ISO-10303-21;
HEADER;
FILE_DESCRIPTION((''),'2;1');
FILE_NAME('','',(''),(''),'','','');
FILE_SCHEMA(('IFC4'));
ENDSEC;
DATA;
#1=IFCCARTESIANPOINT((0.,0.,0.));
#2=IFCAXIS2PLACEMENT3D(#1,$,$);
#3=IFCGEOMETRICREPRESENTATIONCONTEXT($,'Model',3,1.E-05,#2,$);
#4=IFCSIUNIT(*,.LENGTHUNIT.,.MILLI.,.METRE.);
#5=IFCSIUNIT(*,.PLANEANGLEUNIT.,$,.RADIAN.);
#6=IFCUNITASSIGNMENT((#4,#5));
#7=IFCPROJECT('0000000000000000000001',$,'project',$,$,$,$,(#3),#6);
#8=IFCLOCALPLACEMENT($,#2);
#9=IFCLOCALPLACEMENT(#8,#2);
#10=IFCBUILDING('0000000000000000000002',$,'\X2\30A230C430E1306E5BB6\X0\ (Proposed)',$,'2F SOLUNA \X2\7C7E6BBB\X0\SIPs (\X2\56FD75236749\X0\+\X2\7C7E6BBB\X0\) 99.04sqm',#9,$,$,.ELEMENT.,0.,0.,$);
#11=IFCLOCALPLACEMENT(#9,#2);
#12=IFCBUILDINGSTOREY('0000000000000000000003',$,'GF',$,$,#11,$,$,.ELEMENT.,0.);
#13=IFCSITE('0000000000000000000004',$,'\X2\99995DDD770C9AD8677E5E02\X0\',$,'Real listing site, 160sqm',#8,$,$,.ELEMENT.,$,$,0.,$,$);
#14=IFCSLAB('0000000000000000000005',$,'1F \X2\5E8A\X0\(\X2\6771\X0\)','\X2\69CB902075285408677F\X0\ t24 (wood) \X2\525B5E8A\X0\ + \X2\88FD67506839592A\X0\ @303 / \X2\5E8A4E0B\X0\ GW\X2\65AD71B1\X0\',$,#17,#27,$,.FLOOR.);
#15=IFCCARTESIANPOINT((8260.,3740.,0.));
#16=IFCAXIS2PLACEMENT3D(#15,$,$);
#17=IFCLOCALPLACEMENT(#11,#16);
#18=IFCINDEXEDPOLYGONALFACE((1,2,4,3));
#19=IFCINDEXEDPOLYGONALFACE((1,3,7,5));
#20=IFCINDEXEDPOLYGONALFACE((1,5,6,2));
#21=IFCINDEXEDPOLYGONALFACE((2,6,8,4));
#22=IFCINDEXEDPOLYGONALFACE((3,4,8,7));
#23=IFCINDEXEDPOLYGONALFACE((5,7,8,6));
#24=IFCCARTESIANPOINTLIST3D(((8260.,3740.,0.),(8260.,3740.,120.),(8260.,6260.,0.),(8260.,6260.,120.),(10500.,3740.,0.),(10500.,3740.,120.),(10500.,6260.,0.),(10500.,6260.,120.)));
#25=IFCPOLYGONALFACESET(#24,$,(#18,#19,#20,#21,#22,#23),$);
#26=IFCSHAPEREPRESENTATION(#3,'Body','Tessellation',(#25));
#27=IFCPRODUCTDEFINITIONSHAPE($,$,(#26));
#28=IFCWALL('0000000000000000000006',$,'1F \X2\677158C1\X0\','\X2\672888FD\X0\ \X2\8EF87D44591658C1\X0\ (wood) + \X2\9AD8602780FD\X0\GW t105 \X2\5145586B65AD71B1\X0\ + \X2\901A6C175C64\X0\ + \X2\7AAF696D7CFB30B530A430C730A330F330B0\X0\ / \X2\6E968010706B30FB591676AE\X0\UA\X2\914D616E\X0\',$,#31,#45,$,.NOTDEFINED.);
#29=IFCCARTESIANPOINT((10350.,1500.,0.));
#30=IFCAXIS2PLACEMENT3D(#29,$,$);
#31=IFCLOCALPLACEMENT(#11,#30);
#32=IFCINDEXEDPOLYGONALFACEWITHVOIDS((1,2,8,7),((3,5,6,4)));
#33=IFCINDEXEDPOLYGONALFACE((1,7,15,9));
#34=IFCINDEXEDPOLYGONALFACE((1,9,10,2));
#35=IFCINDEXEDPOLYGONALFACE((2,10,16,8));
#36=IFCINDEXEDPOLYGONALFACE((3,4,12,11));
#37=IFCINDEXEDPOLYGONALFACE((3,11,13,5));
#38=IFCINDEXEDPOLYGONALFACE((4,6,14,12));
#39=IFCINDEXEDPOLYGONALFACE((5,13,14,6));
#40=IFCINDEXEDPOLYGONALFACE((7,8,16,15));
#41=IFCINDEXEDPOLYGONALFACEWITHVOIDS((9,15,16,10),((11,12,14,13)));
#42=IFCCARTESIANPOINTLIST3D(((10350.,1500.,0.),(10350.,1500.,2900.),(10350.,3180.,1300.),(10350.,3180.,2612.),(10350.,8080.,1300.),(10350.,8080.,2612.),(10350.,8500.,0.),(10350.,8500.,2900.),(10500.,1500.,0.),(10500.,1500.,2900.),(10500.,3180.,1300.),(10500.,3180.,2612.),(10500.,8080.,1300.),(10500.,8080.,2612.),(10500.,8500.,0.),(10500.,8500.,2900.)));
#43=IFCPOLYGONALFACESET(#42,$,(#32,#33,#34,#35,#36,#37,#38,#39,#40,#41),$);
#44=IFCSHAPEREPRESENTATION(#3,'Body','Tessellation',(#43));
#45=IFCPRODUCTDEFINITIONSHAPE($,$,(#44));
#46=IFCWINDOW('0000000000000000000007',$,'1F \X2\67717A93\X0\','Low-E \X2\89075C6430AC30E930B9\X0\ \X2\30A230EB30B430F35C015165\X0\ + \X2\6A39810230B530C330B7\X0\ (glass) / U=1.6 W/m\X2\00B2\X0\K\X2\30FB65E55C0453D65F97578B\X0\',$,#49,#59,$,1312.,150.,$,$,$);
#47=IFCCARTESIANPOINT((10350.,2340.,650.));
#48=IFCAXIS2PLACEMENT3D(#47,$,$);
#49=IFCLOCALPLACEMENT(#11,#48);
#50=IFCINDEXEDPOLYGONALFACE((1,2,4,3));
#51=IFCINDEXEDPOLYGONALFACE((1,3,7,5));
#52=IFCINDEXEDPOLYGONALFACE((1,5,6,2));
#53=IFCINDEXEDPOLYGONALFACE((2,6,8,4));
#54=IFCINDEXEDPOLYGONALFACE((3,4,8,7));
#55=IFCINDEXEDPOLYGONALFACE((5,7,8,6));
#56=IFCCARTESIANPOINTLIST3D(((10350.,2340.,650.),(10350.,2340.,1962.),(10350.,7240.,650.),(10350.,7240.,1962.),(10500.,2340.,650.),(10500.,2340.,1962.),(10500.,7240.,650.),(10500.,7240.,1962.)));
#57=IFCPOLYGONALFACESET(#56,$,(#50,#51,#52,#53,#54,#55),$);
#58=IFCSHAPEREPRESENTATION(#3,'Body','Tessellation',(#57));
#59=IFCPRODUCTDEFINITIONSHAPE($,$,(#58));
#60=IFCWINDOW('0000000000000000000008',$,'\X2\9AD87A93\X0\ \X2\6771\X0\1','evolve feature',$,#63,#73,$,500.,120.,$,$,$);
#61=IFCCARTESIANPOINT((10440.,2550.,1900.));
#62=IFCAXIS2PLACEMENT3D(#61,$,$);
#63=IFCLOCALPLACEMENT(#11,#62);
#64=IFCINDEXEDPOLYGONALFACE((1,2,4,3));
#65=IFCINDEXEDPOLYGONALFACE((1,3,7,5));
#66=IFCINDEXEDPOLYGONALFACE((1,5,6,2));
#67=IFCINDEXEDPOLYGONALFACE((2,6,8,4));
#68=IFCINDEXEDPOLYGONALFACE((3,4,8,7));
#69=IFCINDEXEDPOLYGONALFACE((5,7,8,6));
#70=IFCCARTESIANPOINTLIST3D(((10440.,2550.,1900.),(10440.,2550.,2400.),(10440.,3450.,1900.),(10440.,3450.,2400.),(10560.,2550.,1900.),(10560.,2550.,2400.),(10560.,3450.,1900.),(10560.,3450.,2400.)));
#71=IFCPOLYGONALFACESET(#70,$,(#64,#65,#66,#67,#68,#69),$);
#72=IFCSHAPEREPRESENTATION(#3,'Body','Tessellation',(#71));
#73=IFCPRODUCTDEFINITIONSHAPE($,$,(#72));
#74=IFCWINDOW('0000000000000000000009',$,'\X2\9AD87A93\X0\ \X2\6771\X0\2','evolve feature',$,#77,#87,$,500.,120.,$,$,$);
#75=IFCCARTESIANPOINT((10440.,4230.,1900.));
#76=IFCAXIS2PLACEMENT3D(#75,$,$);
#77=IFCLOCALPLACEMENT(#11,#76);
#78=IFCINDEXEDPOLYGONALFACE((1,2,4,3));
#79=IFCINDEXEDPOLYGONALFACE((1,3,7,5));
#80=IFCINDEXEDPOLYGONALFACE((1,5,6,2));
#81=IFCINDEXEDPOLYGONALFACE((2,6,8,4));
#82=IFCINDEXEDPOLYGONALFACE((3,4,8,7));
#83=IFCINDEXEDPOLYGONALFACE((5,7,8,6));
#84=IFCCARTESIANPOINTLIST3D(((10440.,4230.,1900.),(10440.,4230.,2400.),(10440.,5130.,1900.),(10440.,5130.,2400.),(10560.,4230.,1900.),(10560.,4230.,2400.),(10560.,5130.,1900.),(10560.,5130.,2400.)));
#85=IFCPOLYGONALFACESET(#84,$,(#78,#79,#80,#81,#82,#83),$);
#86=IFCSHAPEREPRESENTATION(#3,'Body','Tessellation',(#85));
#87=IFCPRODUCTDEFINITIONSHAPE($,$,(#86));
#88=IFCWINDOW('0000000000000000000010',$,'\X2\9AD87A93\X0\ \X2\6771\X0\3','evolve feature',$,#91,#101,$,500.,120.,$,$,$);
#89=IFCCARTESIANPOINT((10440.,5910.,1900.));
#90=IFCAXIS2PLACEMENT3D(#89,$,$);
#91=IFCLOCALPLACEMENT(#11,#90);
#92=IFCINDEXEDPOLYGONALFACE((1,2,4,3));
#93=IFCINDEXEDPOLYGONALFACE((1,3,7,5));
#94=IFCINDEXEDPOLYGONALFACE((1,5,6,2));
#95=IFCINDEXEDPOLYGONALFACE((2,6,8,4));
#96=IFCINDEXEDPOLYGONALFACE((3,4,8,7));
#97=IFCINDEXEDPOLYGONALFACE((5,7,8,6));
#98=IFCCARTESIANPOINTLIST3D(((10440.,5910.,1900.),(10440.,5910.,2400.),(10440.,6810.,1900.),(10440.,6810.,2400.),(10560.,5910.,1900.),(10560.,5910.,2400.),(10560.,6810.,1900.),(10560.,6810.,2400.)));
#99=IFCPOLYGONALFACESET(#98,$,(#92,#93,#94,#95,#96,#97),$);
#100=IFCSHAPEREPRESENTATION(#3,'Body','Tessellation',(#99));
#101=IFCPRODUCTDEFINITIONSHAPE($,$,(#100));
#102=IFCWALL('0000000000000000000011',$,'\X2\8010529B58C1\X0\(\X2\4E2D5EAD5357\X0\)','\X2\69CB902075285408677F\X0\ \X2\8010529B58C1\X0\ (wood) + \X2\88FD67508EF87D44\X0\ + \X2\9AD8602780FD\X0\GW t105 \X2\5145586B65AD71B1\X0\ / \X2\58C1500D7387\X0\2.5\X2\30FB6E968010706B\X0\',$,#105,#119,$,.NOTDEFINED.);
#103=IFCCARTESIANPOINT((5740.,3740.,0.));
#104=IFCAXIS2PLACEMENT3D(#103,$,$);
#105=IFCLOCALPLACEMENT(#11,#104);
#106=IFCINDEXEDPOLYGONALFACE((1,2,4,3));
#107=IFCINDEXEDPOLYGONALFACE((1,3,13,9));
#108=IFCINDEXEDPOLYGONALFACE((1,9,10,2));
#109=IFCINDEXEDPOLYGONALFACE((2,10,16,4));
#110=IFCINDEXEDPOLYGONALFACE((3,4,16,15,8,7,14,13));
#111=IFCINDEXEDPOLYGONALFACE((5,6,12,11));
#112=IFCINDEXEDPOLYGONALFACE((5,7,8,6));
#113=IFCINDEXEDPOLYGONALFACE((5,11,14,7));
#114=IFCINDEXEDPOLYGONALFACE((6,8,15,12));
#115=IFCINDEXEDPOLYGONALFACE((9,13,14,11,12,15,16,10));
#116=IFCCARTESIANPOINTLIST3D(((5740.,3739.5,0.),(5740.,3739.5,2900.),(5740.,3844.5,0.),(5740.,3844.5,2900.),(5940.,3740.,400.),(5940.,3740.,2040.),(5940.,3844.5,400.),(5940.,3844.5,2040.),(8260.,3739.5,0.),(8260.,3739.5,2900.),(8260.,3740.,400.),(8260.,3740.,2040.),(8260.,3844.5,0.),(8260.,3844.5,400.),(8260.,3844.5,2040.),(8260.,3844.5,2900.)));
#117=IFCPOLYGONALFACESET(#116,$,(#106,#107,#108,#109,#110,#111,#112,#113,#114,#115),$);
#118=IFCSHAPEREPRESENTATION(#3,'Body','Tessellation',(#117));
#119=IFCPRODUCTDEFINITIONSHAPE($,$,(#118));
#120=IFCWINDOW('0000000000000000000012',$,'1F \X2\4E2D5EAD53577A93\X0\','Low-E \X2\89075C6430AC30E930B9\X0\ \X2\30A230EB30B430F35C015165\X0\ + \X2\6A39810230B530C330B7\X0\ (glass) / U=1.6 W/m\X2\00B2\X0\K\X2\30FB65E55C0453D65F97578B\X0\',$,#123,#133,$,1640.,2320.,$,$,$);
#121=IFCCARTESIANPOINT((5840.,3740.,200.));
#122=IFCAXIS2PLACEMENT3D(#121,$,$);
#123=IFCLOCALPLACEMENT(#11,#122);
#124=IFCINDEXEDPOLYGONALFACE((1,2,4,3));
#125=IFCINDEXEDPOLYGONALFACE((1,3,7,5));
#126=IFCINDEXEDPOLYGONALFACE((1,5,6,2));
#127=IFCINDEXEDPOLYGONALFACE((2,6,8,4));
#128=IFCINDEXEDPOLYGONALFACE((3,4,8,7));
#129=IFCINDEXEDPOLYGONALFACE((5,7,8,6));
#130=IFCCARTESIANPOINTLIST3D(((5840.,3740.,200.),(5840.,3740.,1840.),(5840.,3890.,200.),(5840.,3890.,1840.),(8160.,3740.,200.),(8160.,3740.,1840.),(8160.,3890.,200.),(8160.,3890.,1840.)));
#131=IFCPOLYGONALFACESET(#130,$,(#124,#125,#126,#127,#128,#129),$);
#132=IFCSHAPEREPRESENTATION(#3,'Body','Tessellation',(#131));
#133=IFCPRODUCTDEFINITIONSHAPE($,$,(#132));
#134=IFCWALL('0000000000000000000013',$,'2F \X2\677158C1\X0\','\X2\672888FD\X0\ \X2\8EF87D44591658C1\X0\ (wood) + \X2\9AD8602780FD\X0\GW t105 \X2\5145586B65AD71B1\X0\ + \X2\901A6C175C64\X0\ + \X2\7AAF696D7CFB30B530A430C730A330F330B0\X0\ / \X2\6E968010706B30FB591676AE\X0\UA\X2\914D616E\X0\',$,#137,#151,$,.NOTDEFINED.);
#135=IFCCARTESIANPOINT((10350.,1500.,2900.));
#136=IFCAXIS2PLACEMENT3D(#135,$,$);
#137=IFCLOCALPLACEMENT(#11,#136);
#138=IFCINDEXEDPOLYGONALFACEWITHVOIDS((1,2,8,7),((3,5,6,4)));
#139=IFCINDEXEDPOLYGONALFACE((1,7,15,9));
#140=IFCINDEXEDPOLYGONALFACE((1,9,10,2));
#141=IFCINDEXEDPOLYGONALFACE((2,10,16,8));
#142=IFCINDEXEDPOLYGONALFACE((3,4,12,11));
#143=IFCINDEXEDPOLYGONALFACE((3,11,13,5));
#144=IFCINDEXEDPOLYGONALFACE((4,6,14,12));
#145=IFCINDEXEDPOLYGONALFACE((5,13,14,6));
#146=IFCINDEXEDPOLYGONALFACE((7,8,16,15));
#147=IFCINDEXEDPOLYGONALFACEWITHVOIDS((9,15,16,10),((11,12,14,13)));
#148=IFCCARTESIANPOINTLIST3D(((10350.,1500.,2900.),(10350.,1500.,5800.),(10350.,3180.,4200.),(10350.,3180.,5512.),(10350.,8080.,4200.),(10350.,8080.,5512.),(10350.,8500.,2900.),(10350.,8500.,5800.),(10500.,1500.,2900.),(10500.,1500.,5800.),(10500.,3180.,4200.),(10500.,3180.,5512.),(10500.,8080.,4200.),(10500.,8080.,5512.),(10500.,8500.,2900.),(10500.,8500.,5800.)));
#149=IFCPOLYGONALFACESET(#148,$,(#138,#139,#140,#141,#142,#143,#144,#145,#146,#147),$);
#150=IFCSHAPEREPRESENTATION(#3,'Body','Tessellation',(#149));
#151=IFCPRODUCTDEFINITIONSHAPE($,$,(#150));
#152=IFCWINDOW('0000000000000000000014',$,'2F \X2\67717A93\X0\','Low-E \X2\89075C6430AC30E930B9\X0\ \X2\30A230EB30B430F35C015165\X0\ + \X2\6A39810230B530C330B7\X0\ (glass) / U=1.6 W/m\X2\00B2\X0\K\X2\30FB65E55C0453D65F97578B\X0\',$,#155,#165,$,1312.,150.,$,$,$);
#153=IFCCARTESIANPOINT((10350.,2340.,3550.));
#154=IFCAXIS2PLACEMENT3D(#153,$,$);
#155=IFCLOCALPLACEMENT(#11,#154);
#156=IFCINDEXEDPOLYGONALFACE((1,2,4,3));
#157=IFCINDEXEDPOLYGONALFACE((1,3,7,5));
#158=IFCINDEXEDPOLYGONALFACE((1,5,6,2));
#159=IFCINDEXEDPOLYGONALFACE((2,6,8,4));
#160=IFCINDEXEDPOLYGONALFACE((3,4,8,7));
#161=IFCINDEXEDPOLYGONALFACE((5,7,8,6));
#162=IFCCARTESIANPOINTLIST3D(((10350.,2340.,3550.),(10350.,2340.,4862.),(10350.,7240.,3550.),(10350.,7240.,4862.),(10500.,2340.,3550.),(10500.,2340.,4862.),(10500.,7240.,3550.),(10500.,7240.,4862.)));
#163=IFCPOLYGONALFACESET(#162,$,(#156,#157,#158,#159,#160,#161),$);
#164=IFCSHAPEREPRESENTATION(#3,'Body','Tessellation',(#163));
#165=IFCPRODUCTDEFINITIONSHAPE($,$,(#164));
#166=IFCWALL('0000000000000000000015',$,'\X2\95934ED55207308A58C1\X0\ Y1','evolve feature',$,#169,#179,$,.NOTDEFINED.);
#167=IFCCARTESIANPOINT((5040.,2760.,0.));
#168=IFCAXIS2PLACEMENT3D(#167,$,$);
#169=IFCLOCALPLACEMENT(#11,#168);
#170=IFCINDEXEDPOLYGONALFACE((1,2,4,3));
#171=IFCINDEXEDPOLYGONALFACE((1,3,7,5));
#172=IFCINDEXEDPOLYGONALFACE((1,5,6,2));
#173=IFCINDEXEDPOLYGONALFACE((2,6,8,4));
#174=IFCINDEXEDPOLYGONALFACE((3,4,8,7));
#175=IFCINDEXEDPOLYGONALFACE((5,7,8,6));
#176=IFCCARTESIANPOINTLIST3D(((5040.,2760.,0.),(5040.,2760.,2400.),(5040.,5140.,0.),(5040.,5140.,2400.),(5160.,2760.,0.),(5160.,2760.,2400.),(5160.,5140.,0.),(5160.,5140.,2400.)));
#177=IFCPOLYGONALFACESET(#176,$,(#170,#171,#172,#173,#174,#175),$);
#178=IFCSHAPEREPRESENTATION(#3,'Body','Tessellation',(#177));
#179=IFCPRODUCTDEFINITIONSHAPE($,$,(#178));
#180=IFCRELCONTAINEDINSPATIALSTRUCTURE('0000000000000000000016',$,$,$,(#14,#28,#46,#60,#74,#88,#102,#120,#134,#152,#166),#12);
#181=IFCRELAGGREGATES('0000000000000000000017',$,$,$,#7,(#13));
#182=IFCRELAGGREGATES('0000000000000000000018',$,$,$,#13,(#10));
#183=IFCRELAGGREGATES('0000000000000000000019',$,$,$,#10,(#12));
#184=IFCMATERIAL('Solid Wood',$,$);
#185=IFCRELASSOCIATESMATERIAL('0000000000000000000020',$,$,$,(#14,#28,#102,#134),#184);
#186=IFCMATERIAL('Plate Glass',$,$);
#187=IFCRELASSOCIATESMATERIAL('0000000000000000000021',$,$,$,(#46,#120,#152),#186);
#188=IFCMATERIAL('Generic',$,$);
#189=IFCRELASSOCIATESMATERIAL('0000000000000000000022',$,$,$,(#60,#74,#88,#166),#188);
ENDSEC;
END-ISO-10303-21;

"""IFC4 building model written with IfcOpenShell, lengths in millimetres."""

from ifc_helpers import new_model, si_unit, frame, frame_2d, origin, place, context, project, spatial, rectangle, extrude, material, element, fill, save


model = new_model("IFC4")

# Units and contexts
model_context = context("Model", 3, precision=1e-05, world=origin())
ifc_project = project(units=[si_unit("LENGTHUNIT", "METRE", prefix="MILLI"), si_unit("PLANEANGLEUNIT", "RADIAN")], contexts=[model_context])

# Site, building, storey
site_placement = place(None, origin())
site = spatial("IfcSite", under=ifc_project, at=site_placement, Name="香川県高松市", ObjectType="Real listing site, 160sqm", CompositionType="ELEMENT", RefElevation=0.0)
building_placement = place(site_placement, origin())
building = spatial("IfcBuilding", under=site, at=building_placement, Name="アツメの家 (Proposed)", ObjectType="2F SOLUNA 籾殻SIPs (国産杉+籾殻) 99.04sqm", CompositionType="ELEMENT", ElevationOfRefHeight=0.0, ElevationOfTerrain=0.0)
storey_placement = place(building_placement, origin())
storey = spatial("IfcBuildingStorey", under=building, at=storey_placement, Name="GF", CompositionType="ELEMENT", Elevation=0.0)

# Slab
ifc_material_1 = material(Name="Solid Wood")
slab_placement = place(storey_placement, frame((8260.0, 3740.0, 0.0)))
element("IfcSlab", 1, at=slab_placement, inside=storey, material=ifc_material_1, Name="1F 床(東)", Description="構造用合板 t24 (wood) 剛床 + 製材根太 @303 / 床下 GW断熱", PredefinedType="FLOOR", context=model_context, shape_type="SweptSolid", body=[
    extrude(rectangle(XDim=2240.0, YDim=2520.0, at=frame_2d((1120.0, 1260.0))), frame((8260.0, 3740.0, 0.0)), (0.0, 0.0, 1.0), 120.0),
])

# Wall, openings, windows
wall_1_placement = place(storey_placement, frame((10350.0, 1500.0, 0.0)))
wall_1 = element("IfcWall", 2, at=wall_1_placement, inside=storey, material=ifc_material_1, Name="1F 東壁", Description="木製 軸組外壁 (wood) + 高性能GW t105 充填断熱 + 通気層 + 窯業系サイディング / 準耐火・外皮UA配慮", PredefinedType="NOTDEFINED", context=model_context, shape_type="SweptSolid", body=[
    extrude(rectangle(XDim=150.0, YDim=7000.0, at=frame_2d((75.0, 3500.0))), frame((10350.0, 1500.0, 0.0)), (0.0, 0.0, 1.0), 2900.0),
])
opening_1_placement = place(storey_placement, frame((10350.0, 2340.0, 650.0)))
opening_1 = element("IfcOpeningElement", 3, at=opening_1_placement, cuts=wall_1, PredefinedType="NOTDEFINED", context=model_context, shape_type="SweptSolid", body=[
    extrude(rectangle(XDim=150.0, YDim=4900.0, at=frame_2d((75.0, 2450.0))), frame((10350.0, 2340.0, 650.0)), (0.0, 0.0, 1.0), 1312.0),
])
opening_2_placement = place(storey_placement, frame((10440.0, 2550.0, 1900.0)))
opening_2 = element("IfcOpeningElement", 4, at=opening_2_placement, cuts=wall_1, PredefinedType="NOTDEFINED", context=model_context, shape_type="SweptSolid", body=[
    extrude(rectangle(XDim=120.0, YDim=900.0, at=frame_2d((60.0, 450.0))), frame((10440.0, 2550.0, 1900.0)), (0.0, 0.0, 1.0), 500.0),
])
opening_3_placement = place(storey_placement, frame((10440.0, 4230.0, 1900.0)))
opening_3 = element("IfcOpeningElement", 5, at=opening_3_placement, cuts=wall_1, PredefinedType="NOTDEFINED", context=model_context, shape_type="SweptSolid", body=[
    extrude(rectangle(XDim=120.0, YDim=900.0, at=frame_2d((60.0, 450.0))), frame((10440.0, 4230.0, 1900.0)), (0.0, 0.0, 1.0), 500.0),
])
opening_4_placement = place(storey_placement, frame((10440.0, 5910.0, 1900.0)))
opening_4 = element("IfcOpeningElement", 6, at=opening_4_placement, cuts=wall_1, PredefinedType="NOTDEFINED", context=model_context, shape_type="SweptSolid", body=[
    extrude(rectangle(XDim=120.0, YDim=900.0, at=frame_2d((60.0, 450.0))), frame((10440.0, 5910.0, 1900.0)), (0.0, 0.0, 1.0), 500.0),
])
ifc_material_2 = material(Name="Plate Glass")
window_1_placement = place(storey_placement, frame((10350.0, 2340.0, 650.0)))
window_1 = element("IfcWindow", 7, at=window_1_placement, inside=storey, material=ifc_material_2, Name="1F 東窓", Description="Low-E 複層ガラス アルゴン封入 + 樹脂サッシ (glass) / U=1.6 W/m²K・日射取得型", OverallHeight=1312.0, OverallWidth=150.0, context=model_context, shape_type="SweptSolid", body=[
    extrude(rectangle(XDim=150.0, YDim=4900.0, at=frame_2d((75.0, 2450.0))), frame((10350.0, 2340.0, 650.0)), (0.0, 0.0, 1.0), 1312.0),
])
fill(opening_1, window_1)
ifc_material_3 = material(Name="Generic")
window_2_placement = place(storey_placement, frame((10440.0, 2550.0, 1900.0)))
window_2 = element("IfcWindow", 8, at=window_2_placement, inside=storey, material=ifc_material_3, Name="高窓 東1", Description="evolve feature", OverallHeight=500.0, OverallWidth=120.0, context=model_context, shape_type="SweptSolid", body=[
    extrude(rectangle(XDim=120.0, YDim=900.0, at=frame_2d((60.0, 450.0))), frame((10440.0, 2550.0, 1900.0)), (0.0, 0.0, 1.0), 500.0),
])
fill(opening_2, window_2)
window_3_placement = place(storey_placement, frame((10440.0, 4230.0, 1900.0)))
window_3 = element("IfcWindow", 9, at=window_3_placement, inside=storey, material=ifc_material_3, Name="高窓 東2", Description="evolve feature", OverallHeight=500.0, OverallWidth=120.0, context=model_context, shape_type="SweptSolid", body=[
    extrude(rectangle(XDim=120.0, YDim=900.0, at=frame_2d((60.0, 450.0))), frame((10440.0, 4230.0, 1900.0)), (0.0, 0.0, 1.0), 500.0),
])
fill(opening_3, window_3)
window_4_placement = place(storey_placement, frame((10440.0, 5910.0, 1900.0)))
window_4 = element("IfcWindow", 10, at=window_4_placement, inside=storey, material=ifc_material_3, Name="高窓 東3", Description="evolve feature", OverallHeight=500.0, OverallWidth=120.0, context=model_context, shape_type="SweptSolid", body=[
    extrude(rectangle(XDim=120.0, YDim=900.0, at=frame_2d((60.0, 450.0))), frame((10440.0, 5910.0, 1900.0)), (0.0, 0.0, 1.0), 500.0),
])
fill(opening_4, window_4)

# Wall, opening, window
wall_2_placement = place(storey_placement, frame((5740.0, 3740.0, 0.0)))
wall_2 = element("IfcWall", 11, at=wall_2_placement, inside=storey, material=ifc_material_1, Name="耐力壁(中庭南)", Description="構造用合板 耐力壁 (wood) + 製材軸組 + 高性能GW t105 充填断熱 / 壁倍率2.5・準耐火", PredefinedType="NOTDEFINED", context=model_context, shape_type="SweptSolid", body=[
    extrude(rectangle(XDim=2520.0, YDim=105.0, at=frame_2d((1260.0, 52.0))), frame((5740.0, 3740.0, 0.0)), (0.0, 0.0, 1.0), 2900.0),
])
opening_5_placement = place(storey_placement, frame((5840.0, 3740.0, 200.0)))
opening_5 = element("IfcOpeningElement", 12, at=opening_5_placement, cuts=wall_2, PredefinedType="NOTDEFINED", context=model_context, shape_type="SweptSolid", body=[
    extrude(rectangle(XDim=2320.0, YDim=150.0, at=frame_2d((1160.0, 75.0))), frame((5840.0, 3740.0, 200.0)), (0.0, 0.0, 1.0), 1640.0),
])
window_5_placement = place(storey_placement, frame((5840.0, 3740.0, 200.0)))
window_5 = element("IfcWindow", 13, at=window_5_placement, inside=storey, material=ifc_material_2, Name="1F 中庭南窓", Description="Low-E 複層ガラス アルゴン封入 + 樹脂サッシ (glass) / U=1.6 W/m²K・日射取得型", OverallHeight=1640.0, OverallWidth=2320.0, context=model_context, shape_type="SweptSolid", body=[
    extrude(rectangle(XDim=2320.0, YDim=150.0, at=frame_2d((1160.0, 75.0))), frame((5840.0, 3740.0, 200.0)), (0.0, 0.0, 1.0), 1640.0),
])
fill(opening_5, window_5)

# Wall, opening, window
wall_3_placement = place(storey_placement, frame((10350.0, 1500.0, 2900.0)))
wall_3 = element("IfcWall", 14, at=wall_3_placement, inside=storey, material=ifc_material_1, Name="2F 東壁", Description="木製 軸組外壁 (wood) + 高性能GW t105 充填断熱 + 通気層 + 窯業系サイディング / 準耐火・外皮UA配慮", PredefinedType="NOTDEFINED", context=model_context, shape_type="SweptSolid", body=[
    extrude(rectangle(XDim=150.0, YDim=7000.0, at=frame_2d((75.0, 3500.0))), frame((10350.0, 1500.0, 2900.0)), (0.0, 0.0, 1.0), 2900.0),
])
opening_6_placement = place(storey_placement, frame((10350.0, 2340.0, 3550.0)))
opening_6 = element("IfcOpeningElement", 15, at=opening_6_placement, cuts=wall_3, PredefinedType="NOTDEFINED", context=model_context, shape_type="SweptSolid", body=[
    extrude(rectangle(XDim=150.0, YDim=4900.0, at=frame_2d((75.0, 2450.0))), frame((10350.0, 2340.0, 3550.0)), (0.0, 0.0, 1.0), 1312.0),
])
window_6_placement = place(storey_placement, frame((10350.0, 2340.0, 3550.0)))
window_6 = element("IfcWindow", 16, at=window_6_placement, inside=storey, material=ifc_material_2, Name="2F 東窓", Description="Low-E 複層ガラス アルゴン封入 + 樹脂サッシ (glass) / U=1.6 W/m²K・日射取得型", OverallHeight=1312.0, OverallWidth=150.0, context=model_context, shape_type="SweptSolid", body=[
    extrude(rectangle(XDim=150.0, YDim=4900.0, at=frame_2d((75.0, 2450.0))), frame((10350.0, 2340.0, 3550.0)), (0.0, 0.0, 1.0), 1312.0),
])
fill(opening_6, window_6)

# Wall
wall_4_placement = place(storey_placement, frame((5040.0, 2760.0, 0.0)))
element("IfcWall", 17, at=wall_4_placement, inside=storey, material=ifc_material_3, Name="間仕切り壁 Y1", Description="evolve feature", PredefinedType="NOTDEFINED", context=model_context, shape_type="SweptSolid", body=[
    extrude(rectangle(XDim=120.0, YDim=2380.0, at=frame_2d((60.0, 1190.0))), frame((5040.0, 2760.0, 0.0)), (0.0, 0.0, 1.0), 2400.0),
])

save(model, "model.ifc")
